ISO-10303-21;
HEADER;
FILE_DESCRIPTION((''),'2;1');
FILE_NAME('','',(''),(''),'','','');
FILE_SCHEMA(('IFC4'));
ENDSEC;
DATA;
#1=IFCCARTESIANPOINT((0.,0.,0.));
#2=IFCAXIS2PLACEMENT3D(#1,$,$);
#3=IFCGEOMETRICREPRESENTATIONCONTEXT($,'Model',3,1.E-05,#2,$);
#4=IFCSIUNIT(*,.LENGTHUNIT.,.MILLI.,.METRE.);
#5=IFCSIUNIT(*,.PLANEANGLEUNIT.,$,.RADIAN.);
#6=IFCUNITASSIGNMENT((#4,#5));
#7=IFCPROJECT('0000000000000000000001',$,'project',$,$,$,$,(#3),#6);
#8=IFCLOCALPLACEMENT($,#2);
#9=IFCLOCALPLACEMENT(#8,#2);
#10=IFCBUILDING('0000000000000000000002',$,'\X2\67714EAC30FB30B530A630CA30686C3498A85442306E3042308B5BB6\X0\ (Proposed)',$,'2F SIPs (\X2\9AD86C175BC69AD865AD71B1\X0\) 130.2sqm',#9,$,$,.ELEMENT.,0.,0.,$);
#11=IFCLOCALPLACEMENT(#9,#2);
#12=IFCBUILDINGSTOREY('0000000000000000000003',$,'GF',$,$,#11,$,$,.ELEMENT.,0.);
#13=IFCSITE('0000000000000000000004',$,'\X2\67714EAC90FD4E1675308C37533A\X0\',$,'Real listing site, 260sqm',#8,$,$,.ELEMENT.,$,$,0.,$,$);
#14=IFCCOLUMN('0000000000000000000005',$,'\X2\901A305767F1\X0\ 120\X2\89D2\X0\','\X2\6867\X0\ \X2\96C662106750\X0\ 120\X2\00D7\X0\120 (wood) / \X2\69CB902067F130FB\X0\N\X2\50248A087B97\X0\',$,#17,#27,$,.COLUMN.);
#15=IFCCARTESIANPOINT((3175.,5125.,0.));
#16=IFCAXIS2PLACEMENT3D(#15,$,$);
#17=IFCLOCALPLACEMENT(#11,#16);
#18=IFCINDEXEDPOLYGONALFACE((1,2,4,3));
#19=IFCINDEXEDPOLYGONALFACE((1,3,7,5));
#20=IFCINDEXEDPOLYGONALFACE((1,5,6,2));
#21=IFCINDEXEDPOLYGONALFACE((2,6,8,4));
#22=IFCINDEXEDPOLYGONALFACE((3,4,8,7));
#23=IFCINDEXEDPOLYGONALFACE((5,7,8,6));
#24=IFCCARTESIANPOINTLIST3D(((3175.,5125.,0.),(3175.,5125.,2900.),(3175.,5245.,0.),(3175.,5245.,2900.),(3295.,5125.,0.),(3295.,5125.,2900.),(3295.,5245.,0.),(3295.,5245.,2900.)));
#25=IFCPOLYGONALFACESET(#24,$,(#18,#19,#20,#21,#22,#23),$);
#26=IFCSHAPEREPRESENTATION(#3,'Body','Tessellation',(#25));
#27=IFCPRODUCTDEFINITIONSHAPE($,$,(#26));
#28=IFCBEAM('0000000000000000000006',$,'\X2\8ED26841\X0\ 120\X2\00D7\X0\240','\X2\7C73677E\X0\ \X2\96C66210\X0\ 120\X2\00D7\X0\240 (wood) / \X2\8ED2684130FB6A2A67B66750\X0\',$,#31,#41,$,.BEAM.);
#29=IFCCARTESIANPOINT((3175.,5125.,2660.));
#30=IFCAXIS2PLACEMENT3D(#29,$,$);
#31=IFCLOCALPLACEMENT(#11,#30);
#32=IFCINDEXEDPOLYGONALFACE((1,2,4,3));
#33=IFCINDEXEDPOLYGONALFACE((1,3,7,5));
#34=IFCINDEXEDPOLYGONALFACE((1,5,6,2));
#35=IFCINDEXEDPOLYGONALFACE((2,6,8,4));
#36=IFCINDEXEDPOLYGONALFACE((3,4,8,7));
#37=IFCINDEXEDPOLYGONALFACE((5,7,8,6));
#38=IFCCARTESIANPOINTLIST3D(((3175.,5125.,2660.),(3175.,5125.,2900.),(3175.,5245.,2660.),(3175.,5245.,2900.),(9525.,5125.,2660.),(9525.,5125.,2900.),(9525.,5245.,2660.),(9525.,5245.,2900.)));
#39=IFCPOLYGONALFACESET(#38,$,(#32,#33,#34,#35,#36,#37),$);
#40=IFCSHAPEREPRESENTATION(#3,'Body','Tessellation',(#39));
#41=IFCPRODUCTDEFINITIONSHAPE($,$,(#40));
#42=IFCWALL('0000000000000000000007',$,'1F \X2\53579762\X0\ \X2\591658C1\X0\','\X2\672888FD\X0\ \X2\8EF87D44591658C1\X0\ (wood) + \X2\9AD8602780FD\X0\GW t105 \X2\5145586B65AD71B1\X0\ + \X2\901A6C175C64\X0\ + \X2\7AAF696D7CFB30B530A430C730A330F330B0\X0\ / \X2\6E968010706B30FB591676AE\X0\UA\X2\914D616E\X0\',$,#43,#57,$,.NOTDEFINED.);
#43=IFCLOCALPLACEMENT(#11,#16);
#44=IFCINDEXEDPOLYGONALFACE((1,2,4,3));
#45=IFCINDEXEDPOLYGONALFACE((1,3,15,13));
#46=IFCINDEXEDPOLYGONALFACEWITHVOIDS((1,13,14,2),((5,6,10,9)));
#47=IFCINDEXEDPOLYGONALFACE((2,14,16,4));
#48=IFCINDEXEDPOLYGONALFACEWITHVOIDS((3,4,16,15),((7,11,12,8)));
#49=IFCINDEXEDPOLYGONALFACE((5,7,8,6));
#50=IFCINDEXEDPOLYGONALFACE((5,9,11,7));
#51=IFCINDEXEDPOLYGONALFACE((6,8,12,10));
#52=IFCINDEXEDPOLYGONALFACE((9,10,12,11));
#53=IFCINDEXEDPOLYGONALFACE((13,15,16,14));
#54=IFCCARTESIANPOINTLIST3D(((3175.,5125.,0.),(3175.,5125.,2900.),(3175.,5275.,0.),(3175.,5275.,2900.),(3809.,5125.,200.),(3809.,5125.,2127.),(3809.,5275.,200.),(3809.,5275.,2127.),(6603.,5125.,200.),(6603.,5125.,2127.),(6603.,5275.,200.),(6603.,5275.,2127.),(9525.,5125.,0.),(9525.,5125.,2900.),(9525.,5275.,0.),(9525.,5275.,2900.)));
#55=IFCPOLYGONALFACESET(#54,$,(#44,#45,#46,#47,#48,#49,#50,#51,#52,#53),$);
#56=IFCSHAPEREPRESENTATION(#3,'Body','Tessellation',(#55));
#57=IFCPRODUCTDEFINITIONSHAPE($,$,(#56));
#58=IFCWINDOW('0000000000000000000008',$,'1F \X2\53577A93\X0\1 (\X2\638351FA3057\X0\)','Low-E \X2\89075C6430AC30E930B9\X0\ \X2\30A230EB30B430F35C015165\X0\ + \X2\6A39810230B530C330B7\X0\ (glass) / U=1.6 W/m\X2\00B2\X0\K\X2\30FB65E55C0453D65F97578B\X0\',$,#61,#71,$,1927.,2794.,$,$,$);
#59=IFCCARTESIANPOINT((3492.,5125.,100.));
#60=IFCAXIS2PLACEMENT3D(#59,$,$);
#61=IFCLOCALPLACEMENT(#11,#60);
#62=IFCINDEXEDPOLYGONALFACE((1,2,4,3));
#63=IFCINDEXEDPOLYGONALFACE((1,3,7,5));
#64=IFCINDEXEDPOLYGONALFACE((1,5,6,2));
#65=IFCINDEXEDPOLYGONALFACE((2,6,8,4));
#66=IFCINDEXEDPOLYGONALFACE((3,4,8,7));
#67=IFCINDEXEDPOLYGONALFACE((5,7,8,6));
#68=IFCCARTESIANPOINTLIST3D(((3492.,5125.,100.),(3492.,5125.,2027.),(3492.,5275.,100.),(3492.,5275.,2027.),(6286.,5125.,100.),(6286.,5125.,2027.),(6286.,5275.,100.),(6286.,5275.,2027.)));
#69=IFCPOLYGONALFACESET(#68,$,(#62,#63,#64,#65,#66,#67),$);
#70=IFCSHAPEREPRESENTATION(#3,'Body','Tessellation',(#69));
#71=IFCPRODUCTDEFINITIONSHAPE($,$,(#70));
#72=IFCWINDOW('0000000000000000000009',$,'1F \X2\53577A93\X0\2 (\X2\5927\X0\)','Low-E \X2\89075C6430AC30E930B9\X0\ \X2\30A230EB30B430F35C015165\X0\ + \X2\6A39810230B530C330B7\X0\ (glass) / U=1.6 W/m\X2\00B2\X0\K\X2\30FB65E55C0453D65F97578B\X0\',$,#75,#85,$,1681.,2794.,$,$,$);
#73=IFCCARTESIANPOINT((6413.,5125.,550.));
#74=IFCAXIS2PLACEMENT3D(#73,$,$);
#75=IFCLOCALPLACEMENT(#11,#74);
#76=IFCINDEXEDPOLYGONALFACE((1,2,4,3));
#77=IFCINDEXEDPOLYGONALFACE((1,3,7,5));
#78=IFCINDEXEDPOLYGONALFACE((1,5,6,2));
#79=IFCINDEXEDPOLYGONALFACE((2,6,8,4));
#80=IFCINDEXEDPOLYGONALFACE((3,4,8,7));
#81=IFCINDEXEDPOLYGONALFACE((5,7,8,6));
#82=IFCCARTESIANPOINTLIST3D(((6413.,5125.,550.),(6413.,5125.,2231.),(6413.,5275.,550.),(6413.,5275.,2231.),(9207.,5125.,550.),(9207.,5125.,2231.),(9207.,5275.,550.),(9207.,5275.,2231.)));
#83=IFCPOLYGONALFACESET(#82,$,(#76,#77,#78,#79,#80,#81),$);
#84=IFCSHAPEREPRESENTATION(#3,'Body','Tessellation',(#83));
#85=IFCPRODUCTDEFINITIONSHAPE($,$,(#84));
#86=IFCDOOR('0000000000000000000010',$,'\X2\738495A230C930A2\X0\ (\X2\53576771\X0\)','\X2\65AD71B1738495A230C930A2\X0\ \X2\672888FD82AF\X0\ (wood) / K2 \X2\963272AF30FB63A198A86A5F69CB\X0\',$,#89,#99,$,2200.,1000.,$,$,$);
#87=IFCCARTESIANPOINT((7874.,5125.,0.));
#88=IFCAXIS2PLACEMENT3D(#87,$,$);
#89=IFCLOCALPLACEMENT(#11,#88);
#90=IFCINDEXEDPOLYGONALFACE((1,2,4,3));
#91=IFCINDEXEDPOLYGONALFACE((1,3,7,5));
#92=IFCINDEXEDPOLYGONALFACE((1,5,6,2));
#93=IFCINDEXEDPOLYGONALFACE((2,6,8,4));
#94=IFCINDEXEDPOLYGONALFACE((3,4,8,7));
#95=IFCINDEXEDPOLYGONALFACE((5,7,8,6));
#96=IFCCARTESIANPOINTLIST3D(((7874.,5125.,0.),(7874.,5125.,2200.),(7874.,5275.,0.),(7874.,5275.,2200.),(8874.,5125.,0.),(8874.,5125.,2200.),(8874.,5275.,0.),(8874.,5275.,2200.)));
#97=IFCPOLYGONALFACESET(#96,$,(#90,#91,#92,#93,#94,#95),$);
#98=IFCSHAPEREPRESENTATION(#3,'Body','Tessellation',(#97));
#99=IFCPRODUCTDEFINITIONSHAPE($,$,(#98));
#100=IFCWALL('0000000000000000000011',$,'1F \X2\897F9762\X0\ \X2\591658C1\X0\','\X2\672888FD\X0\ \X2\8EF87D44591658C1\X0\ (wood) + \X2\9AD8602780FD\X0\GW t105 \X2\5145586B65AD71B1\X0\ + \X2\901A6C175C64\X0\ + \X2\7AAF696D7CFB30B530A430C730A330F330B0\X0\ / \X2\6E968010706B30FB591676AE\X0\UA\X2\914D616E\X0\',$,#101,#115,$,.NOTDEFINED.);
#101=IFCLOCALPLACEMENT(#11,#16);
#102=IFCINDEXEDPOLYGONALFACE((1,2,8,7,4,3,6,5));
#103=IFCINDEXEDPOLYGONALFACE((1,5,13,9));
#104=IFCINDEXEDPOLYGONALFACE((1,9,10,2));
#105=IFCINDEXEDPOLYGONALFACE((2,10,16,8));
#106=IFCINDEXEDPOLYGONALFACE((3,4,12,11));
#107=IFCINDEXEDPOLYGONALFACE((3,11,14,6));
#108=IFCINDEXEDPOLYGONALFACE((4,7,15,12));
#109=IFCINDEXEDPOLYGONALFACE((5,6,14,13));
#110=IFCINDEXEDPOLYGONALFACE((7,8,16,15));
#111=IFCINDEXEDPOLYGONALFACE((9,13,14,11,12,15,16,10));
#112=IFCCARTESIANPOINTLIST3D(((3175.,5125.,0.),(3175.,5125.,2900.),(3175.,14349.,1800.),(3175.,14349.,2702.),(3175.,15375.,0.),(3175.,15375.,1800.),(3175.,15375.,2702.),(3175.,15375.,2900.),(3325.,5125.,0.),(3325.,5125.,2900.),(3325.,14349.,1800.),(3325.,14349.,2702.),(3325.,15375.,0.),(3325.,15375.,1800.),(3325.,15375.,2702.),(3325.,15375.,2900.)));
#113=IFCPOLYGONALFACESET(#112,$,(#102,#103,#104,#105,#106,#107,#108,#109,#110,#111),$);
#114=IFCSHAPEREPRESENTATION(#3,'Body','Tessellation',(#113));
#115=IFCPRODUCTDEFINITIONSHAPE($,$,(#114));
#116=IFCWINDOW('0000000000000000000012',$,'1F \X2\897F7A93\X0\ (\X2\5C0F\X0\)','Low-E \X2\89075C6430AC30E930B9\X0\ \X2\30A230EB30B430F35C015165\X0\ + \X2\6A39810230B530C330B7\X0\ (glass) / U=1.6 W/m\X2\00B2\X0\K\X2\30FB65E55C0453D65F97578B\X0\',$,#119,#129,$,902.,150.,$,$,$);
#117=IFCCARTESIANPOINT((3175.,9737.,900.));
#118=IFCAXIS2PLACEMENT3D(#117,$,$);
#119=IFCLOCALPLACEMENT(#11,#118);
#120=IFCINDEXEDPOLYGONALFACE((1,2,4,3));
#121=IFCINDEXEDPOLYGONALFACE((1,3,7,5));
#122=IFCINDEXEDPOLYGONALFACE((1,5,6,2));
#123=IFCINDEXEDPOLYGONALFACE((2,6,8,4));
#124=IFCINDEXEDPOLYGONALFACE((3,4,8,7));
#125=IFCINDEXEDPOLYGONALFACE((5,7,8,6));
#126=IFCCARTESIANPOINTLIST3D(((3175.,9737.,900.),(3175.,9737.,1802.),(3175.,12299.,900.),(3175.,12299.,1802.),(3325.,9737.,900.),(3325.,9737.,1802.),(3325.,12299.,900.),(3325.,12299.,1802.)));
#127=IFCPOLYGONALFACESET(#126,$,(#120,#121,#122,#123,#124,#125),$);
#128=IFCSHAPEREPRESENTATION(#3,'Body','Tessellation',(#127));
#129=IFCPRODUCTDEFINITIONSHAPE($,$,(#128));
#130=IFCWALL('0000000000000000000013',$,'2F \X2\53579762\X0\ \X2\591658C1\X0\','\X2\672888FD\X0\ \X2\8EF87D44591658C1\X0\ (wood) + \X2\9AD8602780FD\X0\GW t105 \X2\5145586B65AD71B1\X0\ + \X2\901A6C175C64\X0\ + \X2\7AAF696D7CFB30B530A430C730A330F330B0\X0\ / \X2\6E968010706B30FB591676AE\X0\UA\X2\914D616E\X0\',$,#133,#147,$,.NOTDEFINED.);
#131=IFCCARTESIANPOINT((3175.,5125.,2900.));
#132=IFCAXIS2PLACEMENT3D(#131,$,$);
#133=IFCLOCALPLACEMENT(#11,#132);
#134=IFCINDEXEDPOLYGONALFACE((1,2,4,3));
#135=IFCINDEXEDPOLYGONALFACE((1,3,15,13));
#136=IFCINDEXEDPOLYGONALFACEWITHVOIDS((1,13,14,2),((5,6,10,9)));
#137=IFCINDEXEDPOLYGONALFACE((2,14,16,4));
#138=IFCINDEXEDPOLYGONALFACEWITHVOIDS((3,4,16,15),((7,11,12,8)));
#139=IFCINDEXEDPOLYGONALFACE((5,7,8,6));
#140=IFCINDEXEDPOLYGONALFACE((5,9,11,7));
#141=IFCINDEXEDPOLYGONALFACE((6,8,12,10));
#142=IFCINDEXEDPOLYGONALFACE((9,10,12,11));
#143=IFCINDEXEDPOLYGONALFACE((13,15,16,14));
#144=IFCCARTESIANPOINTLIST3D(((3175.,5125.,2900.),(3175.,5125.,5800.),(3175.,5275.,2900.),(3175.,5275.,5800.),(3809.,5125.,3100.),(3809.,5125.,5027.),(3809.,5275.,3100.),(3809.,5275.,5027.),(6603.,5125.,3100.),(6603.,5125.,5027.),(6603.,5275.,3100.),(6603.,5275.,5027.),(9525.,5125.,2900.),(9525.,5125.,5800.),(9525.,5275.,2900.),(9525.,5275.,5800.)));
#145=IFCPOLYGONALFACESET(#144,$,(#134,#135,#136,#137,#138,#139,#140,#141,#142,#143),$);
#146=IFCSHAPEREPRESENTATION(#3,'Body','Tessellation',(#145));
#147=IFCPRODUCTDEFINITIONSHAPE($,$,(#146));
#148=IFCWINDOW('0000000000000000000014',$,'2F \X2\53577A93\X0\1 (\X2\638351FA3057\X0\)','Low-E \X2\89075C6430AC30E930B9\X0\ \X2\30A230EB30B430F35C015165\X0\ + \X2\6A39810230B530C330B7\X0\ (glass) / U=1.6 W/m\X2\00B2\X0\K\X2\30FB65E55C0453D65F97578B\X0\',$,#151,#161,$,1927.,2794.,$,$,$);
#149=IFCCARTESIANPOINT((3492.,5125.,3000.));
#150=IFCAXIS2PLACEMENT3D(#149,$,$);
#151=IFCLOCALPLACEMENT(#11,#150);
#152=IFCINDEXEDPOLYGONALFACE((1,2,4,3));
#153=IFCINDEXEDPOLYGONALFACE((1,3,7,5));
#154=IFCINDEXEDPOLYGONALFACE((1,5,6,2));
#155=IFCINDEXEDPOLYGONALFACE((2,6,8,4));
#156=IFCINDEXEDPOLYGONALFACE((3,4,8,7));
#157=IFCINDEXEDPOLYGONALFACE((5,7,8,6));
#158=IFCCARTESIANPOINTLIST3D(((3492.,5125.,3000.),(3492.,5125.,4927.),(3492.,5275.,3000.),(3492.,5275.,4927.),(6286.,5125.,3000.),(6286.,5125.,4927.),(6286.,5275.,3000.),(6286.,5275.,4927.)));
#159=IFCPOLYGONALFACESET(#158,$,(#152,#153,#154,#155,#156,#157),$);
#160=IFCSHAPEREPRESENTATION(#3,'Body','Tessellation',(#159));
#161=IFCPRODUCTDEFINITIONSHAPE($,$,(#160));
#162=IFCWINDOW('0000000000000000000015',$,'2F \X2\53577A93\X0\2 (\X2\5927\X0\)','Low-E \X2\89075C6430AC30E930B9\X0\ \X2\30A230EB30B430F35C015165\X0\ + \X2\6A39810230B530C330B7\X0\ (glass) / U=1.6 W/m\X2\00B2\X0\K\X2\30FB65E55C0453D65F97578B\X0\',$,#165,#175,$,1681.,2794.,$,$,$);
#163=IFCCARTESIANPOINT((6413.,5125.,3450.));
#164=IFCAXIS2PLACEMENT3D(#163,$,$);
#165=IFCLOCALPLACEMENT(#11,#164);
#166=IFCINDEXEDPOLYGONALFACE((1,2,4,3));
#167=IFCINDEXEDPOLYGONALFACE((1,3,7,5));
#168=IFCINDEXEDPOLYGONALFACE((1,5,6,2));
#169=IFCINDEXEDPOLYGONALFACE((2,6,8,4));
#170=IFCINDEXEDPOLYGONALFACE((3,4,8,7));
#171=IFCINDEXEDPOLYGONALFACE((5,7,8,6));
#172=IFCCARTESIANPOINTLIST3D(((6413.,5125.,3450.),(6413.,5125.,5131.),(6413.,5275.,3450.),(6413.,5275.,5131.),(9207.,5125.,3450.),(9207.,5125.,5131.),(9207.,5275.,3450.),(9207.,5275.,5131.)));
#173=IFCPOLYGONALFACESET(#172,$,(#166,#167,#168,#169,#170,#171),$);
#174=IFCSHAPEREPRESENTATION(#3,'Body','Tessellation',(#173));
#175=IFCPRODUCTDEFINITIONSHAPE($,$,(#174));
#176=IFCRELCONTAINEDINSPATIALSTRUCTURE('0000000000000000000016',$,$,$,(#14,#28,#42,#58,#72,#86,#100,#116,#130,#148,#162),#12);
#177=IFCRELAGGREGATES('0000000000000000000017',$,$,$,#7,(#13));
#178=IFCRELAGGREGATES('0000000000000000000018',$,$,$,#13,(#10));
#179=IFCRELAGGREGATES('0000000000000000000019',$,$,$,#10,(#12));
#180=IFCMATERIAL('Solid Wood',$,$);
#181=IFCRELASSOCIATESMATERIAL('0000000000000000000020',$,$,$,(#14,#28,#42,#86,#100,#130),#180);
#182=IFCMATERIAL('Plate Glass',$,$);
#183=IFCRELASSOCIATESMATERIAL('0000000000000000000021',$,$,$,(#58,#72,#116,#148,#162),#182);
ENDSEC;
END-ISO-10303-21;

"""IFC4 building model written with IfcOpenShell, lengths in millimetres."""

from ifc_helpers import new_model, si_unit, frame, frame_2d, origin, place, context, project, spatial, rectangle, extrude, material, element, fill, save


model = new_model("IFC4")

# Units and contexts
model_context = context("Model", 3, precision=1e-05, world=origin())
ifc_project = project(units=[si_unit("LENGTHUNIT", "METRE", prefix="MILLI"), si_unit("PLANEANGLEUNIT", "RADIAN")], contexts=[model_context])

# Site, building, storey
site_placement = place(None, origin())
site = spatial("IfcSite", under=ifc_project, at=site_placement, Name="東京都世田谷区", ObjectType="Real listing site, 260sqm", CompositionType="ELEMENT", RefElevation=0.0)
building_placement = place(site_placement, origin())
building = spatial("IfcBuilding", under=site, at=building_placement, Name="東京・サウナと水風呂のある家 (Proposed)", ObjectType="2F SIPs (高気密高断熱) 130.2sqm", CompositionType="ELEMENT", ElevationOfRefHeight=0.0, ElevationOfTerrain=0.0)
storey_placement = place(building_placement, origin())
storey = spatial("IfcBuildingStorey", under=building, at=storey_placement, Name="GF", CompositionType="ELEMENT", Elevation=0.0)

# Column
ifc_material_1 = material(Name="Solid Wood")
column_placement = place(storey_placement, frame((3175.0, 5125.0, 0.0)))
element("IfcColumn", 1, at=column_placement, inside=storey, material=ifc_material_1, Name="通し柱 120角", Description="桧 集成材 120×120 (wood) / 構造柱・N値計算", PredefinedType="COLUMN", context=model_context, shape_type="SweptSolid", body=[
    extrude(rectangle(XDim=120.0, YDim=120.0, at=frame_2d((60.0, 60.0))), frame((3175.0, 5125.0, 0.0)), (0.0, 0.0, 1.0), 2900.0),
])

# Beam
beam_1_placement = place(storey_placement, frame((3175.0, 5125.0, 2660.0)))
element("IfcBeam", 2, at=beam_1_placement, inside=storey, material=ifc_material_1, Name="軒桁 120×240", Description="米松 集成 120×240 (wood) / 軒桁・横架材", PredefinedType="BEAM", context=model_context, shape_type="SweptSolid", body=[
    extrude(rectangle(XDim=6350.0, YDim=120.0, at=frame_2d((3175.0, 60.0))), frame((3175.0, 5125.0, 2660.0)), (0.0, 0.0, 1.0), 240.0),
])

# Wall, openings, windows, door
wall_1_placement = place(storey_placement, frame((3175.0, 5125.0, 0.0)))
wall_1 = element("IfcWall", 3, at=wall_1_placement, inside=storey, material=ifc_material_1, Name="1F 南面 外壁", Description="木製 軸組外壁 (wood) + 高性能GW t105 充填断熱 + 通気層 + 窯業系サイディング / 準耐火・外皮UA配慮", PredefinedType="NOTDEFINED", context=model_context, shape_type="SweptSolid", body=[
    extrude(rectangle(XDim=6350.0, YDim=150.0, at=frame_2d((3175.0, 75.0))), frame((3175.0, 5125.0, 0.0)), (0.0, 0.0, 1.0), 2900.0),
])
opening_1_placement = place(storey_placement, frame((3492.0, 5125.0, 100.0)))
opening_1 = element("IfcOpeningElement", 4, at=opening_1_placement, cuts=wall_1, PredefinedType="NOTDEFINED", context=model_context, shape_type="SweptSolid", body=[
    extrude(rectangle(XDim=2794.0, YDim=150.0, at=frame_2d((1397.0, 75.0))), frame((3492.0, 5125.0, 100.0)), (0.0, 0.0, 1.0), 1927.0),
])
opening_2_placement = place(storey_placement, frame((6413.0, 5125.0, 550.0)))
opening_2 = element("IfcOpeningElement", 5, at=opening_2_placement, cuts=wall_1, PredefinedType="NOTDEFINED", context=model_context, shape_type="SweptSolid", body=[
    extrude(rectangle(XDim=2794.0, YDim=150.0, at=frame_2d((1397.0, 75.0))), frame((6413.0, 5125.0, 550.0)), (0.0, 0.0, 1.0), 1681.0),
])
opening_3_placement = place(storey_placement, frame((7874.0, 5125.0, 0.0)))
opening_3 = element("IfcOpeningElement", 6, at=opening_3_placement, cuts=wall_1, PredefinedType="NOTDEFINED", context=model_context, shape_type="SweptSolid", body=[
    extrude(rectangle(XDim=1000.0, YDim=150.0, at=frame_2d((500.0, 75.0))), frame((7874.0, 5125.0, 0.0)), (0.0, 0.0, 1.0), 2200.0),
])
ifc_material_2 = material(Name="Plate Glass")
window_1_placement = place(storey_placement, frame((3492.0, 5125.0, 100.0)))
window_1 = element("IfcWindow", 7, at=window_1_placement, inside=storey, material=ifc_material_2, Name="1F 南窓1 (掃出し)", Description="Low-E 複層ガラス アルゴン封入 + 樹脂サッシ (glass) / U=1.6 W/m²K・日射取得型", OverallHeight=1927.0, OverallWidth=2794.0, context=model_context, shape_type="SweptSolid", body=[
    extrude(rectangle(XDim=2794.0, YDim=150.0, at=frame_2d((1397.0, 75.0))), frame((3492.0, 5125.0, 100.0)), (0.0, 0.0, 1.0), 1927.0),
])
fill(opening_1, window_1)
window_2_placement = place(storey_placement, frame((6413.0, 5125.0, 550.0)))
window_2 = element("IfcWindow", 8, at=window_2_placement, inside=storey, material=ifc_material_2, Name="1F 南窓2 (大)", Description="Low-E 複層ガラス アルゴン封入 + 樹脂サッシ (glass) / U=1.6 W/m²K・日射取得型", OverallHeight=1681.0, OverallWidth=2794.0, context=model_context, shape_type="SweptSolid", body=[
    extrude(rectangle(XDim=2794.0, YDim=150.0, at=frame_2d((1397.0, 75.0))), frame((6413.0, 5125.0, 550.0)), (0.0, 0.0, 1.0), 1681.0),
])
fill(opening_2, window_2)
door_placement = place(storey_placement, frame((7874.0, 5125.0, 0.0)))
door = element("IfcDoor", 9, at=door_placement, inside=storey, material=ifc_material_1, Name="玄関ドア (南東)", Description="断熱玄関ドア 木製芯 (wood) / K2 防犯・採風機構", OverallHeight=2200.0, OverallWidth=1000.0, context=model_context, shape_type="SweptSolid", body=[
    extrude(rectangle(XDim=1000.0, YDim=150.0, at=frame_2d((500.0, 75.0))), frame((7874.0, 5125.0, 0.0)), (0.0, 0.0, 1.0), 2200.0),
])
fill(opening_3, door)

# Wall, opening, window
wall_2_placement = place(storey_placement, frame((3175.0, 5125.0, 0.0)))
wall_2 = element("IfcWall", 10, at=wall_2_placement, inside=storey, material=ifc_material_1, Name="1F 西面 外壁", Description="木製 軸組外壁 (wood) + 高性能GW t105 充填断熱 + 通気層 + 窯業系サイディング / 準耐火・外皮UA配慮", PredefinedType="NOTDEFINED", context=model_context, shape_type="SweptSolid", body=[
    extrude(rectangle(XDim=150.0, YDim=10250.0, at=frame_2d((75.0, 5125.0))), frame((3175.0, 5125.0, 0.0)), (0.0, 0.0, 1.0), 2900.0),
])
opening_4_placement = place(storey_placement, frame((3175.0, 9737.0, 900.0)))
opening_4 = element("IfcOpeningElement", 11, at=opening_4_placement, cuts=wall_2, PredefinedType="NOTDEFINED", context=model_context, shape_type="SweptSolid", body=[
    extrude(rectangle(XDim=150.0, YDim=2562.0, at=frame_2d((75.0, 1281.0))), frame((3175.0, 9737.0, 900.0)), (0.0, 0.0, 1.0), 902.0),
])
window_3_placement = place(storey_placement, frame((3175.0, 9737.0, 900.0)))
window_3 = element("IfcWindow", 12, at=window_3_placement, inside=storey, material=ifc_material_2, Name="1F 西窓 (小)", Description="Low-E 複層ガラス アルゴン封入 + 樹脂サッシ (glass) / U=1.6 W/m²K・日射取得型", OverallHeight=902.0, OverallWidth=150.0, context=model_context, shape_type="SweptSolid", body=[
    extrude(rectangle(XDim=150.0, YDim=2562.0, at=frame_2d((75.0, 1281.0))), frame((3175.0, 9737.0, 900.0)), (0.0, 0.0, 1.0), 902.0),
])
fill(opening_4, window_3)

# Wall, openings, windows
wall_3_placement = place(storey_placement, frame((3175.0, 5125.0, 2900.0)))
wall_3 = element("IfcWall", 13, at=wall_3_placement, inside=storey, material=ifc_material_1, Name="2F 南面 外壁", Description="木製 軸組外壁 (wood) + 高性能GW t105 充填断熱 + 通気層 + 窯業系サイディング / 準耐火・外皮UA配慮", PredefinedType="NOTDEFINED", context=model_context, shape_type="SweptSolid", body=[
    extrude(rectangle(XDim=6350.0, YDim=150.0, at=frame_2d((3175.0, 75.0))), frame((3175.0, 5125.0, 2900.0)), (0.0, 0.0, 1.0), 2900.0),
])
opening_5_placement = place(storey_placement, frame((3492.0, 5125.0, 3000.0)))
opening_5 = element("IfcOpeningElement", 14, at=opening_5_placement, cuts=wall_3, PredefinedType="NOTDEFINED", context=model_context, shape_type="SweptSolid", body=[
    extrude(rectangle(XDim=2794.0, YDim=150.0, at=frame_2d((1397.0, 75.0))), frame((3492.0, 5125.0, 3000.0)), (0.0, 0.0, 1.0), 1927.0),
])
opening_6_placement = place(storey_placement, frame((6413.0, 5125.0, 3450.0)))
opening_6 = element("IfcOpeningElement", 15, at=opening_6_placement, cuts=wall_3, PredefinedType="NOTDEFINED", context=model_context, shape_type="SweptSolid", body=[
    extrude(rectangle(XDim=2794.0, YDim=150.0, at=frame_2d((1397.0, 75.0))), frame((6413.0, 5125.0, 3450.0)), (0.0, 0.0, 1.0), 1681.0),
])
window_4_placement = place(storey_placement, frame((3492.0, 5125.0, 3000.0)))
window_4 = element("IfcWindow", 16, at=window_4_placement, inside=storey, material=ifc_material_2, Name="2F 南窓1 (掃出し)", Description="Low-E 複層ガラス アルゴン封入 + 樹脂サッシ (glass) / U=1.6 W/m²K・日射取得型", OverallHeight=1927.0, OverallWidth=2794.0, context=model_context, shape_type="SweptSolid", body=[
    extrude(rectangle(XDim=2794.0, YDim=150.0, at=frame_2d((1397.0, 75.0))), frame((3492.0, 5125.0, 3000.0)), (0.0, 0.0, 1.0), 1927.0),
])
fill(opening_5, window_4)
window_5_placement = place(storey_placement, frame((6413.0, 5125.0, 3450.0)))
window_5 = element("IfcWindow", 17, at=window_5_placement, inside=storey, material=ifc_material_2, Name="2F 南窓2 (大)", Description="Low-E 複層ガラス アルゴン封入 + 樹脂サッシ (glass) / U=1.6 W/m²K・日射取得型", OverallHeight=1681.0, OverallWidth=2794.0, context=model_context, shape_type="SweptSolid", body=[
    extrude(rectangle(XDim=2794.0, YDim=150.0, at=frame_2d((1397.0, 75.0))), frame((6413.0, 5125.0, 3450.0)), (0.0, 0.0, 1.0), 1681.0),
])
fill(opening_6, window_5)

save(model, "model.ifc")
